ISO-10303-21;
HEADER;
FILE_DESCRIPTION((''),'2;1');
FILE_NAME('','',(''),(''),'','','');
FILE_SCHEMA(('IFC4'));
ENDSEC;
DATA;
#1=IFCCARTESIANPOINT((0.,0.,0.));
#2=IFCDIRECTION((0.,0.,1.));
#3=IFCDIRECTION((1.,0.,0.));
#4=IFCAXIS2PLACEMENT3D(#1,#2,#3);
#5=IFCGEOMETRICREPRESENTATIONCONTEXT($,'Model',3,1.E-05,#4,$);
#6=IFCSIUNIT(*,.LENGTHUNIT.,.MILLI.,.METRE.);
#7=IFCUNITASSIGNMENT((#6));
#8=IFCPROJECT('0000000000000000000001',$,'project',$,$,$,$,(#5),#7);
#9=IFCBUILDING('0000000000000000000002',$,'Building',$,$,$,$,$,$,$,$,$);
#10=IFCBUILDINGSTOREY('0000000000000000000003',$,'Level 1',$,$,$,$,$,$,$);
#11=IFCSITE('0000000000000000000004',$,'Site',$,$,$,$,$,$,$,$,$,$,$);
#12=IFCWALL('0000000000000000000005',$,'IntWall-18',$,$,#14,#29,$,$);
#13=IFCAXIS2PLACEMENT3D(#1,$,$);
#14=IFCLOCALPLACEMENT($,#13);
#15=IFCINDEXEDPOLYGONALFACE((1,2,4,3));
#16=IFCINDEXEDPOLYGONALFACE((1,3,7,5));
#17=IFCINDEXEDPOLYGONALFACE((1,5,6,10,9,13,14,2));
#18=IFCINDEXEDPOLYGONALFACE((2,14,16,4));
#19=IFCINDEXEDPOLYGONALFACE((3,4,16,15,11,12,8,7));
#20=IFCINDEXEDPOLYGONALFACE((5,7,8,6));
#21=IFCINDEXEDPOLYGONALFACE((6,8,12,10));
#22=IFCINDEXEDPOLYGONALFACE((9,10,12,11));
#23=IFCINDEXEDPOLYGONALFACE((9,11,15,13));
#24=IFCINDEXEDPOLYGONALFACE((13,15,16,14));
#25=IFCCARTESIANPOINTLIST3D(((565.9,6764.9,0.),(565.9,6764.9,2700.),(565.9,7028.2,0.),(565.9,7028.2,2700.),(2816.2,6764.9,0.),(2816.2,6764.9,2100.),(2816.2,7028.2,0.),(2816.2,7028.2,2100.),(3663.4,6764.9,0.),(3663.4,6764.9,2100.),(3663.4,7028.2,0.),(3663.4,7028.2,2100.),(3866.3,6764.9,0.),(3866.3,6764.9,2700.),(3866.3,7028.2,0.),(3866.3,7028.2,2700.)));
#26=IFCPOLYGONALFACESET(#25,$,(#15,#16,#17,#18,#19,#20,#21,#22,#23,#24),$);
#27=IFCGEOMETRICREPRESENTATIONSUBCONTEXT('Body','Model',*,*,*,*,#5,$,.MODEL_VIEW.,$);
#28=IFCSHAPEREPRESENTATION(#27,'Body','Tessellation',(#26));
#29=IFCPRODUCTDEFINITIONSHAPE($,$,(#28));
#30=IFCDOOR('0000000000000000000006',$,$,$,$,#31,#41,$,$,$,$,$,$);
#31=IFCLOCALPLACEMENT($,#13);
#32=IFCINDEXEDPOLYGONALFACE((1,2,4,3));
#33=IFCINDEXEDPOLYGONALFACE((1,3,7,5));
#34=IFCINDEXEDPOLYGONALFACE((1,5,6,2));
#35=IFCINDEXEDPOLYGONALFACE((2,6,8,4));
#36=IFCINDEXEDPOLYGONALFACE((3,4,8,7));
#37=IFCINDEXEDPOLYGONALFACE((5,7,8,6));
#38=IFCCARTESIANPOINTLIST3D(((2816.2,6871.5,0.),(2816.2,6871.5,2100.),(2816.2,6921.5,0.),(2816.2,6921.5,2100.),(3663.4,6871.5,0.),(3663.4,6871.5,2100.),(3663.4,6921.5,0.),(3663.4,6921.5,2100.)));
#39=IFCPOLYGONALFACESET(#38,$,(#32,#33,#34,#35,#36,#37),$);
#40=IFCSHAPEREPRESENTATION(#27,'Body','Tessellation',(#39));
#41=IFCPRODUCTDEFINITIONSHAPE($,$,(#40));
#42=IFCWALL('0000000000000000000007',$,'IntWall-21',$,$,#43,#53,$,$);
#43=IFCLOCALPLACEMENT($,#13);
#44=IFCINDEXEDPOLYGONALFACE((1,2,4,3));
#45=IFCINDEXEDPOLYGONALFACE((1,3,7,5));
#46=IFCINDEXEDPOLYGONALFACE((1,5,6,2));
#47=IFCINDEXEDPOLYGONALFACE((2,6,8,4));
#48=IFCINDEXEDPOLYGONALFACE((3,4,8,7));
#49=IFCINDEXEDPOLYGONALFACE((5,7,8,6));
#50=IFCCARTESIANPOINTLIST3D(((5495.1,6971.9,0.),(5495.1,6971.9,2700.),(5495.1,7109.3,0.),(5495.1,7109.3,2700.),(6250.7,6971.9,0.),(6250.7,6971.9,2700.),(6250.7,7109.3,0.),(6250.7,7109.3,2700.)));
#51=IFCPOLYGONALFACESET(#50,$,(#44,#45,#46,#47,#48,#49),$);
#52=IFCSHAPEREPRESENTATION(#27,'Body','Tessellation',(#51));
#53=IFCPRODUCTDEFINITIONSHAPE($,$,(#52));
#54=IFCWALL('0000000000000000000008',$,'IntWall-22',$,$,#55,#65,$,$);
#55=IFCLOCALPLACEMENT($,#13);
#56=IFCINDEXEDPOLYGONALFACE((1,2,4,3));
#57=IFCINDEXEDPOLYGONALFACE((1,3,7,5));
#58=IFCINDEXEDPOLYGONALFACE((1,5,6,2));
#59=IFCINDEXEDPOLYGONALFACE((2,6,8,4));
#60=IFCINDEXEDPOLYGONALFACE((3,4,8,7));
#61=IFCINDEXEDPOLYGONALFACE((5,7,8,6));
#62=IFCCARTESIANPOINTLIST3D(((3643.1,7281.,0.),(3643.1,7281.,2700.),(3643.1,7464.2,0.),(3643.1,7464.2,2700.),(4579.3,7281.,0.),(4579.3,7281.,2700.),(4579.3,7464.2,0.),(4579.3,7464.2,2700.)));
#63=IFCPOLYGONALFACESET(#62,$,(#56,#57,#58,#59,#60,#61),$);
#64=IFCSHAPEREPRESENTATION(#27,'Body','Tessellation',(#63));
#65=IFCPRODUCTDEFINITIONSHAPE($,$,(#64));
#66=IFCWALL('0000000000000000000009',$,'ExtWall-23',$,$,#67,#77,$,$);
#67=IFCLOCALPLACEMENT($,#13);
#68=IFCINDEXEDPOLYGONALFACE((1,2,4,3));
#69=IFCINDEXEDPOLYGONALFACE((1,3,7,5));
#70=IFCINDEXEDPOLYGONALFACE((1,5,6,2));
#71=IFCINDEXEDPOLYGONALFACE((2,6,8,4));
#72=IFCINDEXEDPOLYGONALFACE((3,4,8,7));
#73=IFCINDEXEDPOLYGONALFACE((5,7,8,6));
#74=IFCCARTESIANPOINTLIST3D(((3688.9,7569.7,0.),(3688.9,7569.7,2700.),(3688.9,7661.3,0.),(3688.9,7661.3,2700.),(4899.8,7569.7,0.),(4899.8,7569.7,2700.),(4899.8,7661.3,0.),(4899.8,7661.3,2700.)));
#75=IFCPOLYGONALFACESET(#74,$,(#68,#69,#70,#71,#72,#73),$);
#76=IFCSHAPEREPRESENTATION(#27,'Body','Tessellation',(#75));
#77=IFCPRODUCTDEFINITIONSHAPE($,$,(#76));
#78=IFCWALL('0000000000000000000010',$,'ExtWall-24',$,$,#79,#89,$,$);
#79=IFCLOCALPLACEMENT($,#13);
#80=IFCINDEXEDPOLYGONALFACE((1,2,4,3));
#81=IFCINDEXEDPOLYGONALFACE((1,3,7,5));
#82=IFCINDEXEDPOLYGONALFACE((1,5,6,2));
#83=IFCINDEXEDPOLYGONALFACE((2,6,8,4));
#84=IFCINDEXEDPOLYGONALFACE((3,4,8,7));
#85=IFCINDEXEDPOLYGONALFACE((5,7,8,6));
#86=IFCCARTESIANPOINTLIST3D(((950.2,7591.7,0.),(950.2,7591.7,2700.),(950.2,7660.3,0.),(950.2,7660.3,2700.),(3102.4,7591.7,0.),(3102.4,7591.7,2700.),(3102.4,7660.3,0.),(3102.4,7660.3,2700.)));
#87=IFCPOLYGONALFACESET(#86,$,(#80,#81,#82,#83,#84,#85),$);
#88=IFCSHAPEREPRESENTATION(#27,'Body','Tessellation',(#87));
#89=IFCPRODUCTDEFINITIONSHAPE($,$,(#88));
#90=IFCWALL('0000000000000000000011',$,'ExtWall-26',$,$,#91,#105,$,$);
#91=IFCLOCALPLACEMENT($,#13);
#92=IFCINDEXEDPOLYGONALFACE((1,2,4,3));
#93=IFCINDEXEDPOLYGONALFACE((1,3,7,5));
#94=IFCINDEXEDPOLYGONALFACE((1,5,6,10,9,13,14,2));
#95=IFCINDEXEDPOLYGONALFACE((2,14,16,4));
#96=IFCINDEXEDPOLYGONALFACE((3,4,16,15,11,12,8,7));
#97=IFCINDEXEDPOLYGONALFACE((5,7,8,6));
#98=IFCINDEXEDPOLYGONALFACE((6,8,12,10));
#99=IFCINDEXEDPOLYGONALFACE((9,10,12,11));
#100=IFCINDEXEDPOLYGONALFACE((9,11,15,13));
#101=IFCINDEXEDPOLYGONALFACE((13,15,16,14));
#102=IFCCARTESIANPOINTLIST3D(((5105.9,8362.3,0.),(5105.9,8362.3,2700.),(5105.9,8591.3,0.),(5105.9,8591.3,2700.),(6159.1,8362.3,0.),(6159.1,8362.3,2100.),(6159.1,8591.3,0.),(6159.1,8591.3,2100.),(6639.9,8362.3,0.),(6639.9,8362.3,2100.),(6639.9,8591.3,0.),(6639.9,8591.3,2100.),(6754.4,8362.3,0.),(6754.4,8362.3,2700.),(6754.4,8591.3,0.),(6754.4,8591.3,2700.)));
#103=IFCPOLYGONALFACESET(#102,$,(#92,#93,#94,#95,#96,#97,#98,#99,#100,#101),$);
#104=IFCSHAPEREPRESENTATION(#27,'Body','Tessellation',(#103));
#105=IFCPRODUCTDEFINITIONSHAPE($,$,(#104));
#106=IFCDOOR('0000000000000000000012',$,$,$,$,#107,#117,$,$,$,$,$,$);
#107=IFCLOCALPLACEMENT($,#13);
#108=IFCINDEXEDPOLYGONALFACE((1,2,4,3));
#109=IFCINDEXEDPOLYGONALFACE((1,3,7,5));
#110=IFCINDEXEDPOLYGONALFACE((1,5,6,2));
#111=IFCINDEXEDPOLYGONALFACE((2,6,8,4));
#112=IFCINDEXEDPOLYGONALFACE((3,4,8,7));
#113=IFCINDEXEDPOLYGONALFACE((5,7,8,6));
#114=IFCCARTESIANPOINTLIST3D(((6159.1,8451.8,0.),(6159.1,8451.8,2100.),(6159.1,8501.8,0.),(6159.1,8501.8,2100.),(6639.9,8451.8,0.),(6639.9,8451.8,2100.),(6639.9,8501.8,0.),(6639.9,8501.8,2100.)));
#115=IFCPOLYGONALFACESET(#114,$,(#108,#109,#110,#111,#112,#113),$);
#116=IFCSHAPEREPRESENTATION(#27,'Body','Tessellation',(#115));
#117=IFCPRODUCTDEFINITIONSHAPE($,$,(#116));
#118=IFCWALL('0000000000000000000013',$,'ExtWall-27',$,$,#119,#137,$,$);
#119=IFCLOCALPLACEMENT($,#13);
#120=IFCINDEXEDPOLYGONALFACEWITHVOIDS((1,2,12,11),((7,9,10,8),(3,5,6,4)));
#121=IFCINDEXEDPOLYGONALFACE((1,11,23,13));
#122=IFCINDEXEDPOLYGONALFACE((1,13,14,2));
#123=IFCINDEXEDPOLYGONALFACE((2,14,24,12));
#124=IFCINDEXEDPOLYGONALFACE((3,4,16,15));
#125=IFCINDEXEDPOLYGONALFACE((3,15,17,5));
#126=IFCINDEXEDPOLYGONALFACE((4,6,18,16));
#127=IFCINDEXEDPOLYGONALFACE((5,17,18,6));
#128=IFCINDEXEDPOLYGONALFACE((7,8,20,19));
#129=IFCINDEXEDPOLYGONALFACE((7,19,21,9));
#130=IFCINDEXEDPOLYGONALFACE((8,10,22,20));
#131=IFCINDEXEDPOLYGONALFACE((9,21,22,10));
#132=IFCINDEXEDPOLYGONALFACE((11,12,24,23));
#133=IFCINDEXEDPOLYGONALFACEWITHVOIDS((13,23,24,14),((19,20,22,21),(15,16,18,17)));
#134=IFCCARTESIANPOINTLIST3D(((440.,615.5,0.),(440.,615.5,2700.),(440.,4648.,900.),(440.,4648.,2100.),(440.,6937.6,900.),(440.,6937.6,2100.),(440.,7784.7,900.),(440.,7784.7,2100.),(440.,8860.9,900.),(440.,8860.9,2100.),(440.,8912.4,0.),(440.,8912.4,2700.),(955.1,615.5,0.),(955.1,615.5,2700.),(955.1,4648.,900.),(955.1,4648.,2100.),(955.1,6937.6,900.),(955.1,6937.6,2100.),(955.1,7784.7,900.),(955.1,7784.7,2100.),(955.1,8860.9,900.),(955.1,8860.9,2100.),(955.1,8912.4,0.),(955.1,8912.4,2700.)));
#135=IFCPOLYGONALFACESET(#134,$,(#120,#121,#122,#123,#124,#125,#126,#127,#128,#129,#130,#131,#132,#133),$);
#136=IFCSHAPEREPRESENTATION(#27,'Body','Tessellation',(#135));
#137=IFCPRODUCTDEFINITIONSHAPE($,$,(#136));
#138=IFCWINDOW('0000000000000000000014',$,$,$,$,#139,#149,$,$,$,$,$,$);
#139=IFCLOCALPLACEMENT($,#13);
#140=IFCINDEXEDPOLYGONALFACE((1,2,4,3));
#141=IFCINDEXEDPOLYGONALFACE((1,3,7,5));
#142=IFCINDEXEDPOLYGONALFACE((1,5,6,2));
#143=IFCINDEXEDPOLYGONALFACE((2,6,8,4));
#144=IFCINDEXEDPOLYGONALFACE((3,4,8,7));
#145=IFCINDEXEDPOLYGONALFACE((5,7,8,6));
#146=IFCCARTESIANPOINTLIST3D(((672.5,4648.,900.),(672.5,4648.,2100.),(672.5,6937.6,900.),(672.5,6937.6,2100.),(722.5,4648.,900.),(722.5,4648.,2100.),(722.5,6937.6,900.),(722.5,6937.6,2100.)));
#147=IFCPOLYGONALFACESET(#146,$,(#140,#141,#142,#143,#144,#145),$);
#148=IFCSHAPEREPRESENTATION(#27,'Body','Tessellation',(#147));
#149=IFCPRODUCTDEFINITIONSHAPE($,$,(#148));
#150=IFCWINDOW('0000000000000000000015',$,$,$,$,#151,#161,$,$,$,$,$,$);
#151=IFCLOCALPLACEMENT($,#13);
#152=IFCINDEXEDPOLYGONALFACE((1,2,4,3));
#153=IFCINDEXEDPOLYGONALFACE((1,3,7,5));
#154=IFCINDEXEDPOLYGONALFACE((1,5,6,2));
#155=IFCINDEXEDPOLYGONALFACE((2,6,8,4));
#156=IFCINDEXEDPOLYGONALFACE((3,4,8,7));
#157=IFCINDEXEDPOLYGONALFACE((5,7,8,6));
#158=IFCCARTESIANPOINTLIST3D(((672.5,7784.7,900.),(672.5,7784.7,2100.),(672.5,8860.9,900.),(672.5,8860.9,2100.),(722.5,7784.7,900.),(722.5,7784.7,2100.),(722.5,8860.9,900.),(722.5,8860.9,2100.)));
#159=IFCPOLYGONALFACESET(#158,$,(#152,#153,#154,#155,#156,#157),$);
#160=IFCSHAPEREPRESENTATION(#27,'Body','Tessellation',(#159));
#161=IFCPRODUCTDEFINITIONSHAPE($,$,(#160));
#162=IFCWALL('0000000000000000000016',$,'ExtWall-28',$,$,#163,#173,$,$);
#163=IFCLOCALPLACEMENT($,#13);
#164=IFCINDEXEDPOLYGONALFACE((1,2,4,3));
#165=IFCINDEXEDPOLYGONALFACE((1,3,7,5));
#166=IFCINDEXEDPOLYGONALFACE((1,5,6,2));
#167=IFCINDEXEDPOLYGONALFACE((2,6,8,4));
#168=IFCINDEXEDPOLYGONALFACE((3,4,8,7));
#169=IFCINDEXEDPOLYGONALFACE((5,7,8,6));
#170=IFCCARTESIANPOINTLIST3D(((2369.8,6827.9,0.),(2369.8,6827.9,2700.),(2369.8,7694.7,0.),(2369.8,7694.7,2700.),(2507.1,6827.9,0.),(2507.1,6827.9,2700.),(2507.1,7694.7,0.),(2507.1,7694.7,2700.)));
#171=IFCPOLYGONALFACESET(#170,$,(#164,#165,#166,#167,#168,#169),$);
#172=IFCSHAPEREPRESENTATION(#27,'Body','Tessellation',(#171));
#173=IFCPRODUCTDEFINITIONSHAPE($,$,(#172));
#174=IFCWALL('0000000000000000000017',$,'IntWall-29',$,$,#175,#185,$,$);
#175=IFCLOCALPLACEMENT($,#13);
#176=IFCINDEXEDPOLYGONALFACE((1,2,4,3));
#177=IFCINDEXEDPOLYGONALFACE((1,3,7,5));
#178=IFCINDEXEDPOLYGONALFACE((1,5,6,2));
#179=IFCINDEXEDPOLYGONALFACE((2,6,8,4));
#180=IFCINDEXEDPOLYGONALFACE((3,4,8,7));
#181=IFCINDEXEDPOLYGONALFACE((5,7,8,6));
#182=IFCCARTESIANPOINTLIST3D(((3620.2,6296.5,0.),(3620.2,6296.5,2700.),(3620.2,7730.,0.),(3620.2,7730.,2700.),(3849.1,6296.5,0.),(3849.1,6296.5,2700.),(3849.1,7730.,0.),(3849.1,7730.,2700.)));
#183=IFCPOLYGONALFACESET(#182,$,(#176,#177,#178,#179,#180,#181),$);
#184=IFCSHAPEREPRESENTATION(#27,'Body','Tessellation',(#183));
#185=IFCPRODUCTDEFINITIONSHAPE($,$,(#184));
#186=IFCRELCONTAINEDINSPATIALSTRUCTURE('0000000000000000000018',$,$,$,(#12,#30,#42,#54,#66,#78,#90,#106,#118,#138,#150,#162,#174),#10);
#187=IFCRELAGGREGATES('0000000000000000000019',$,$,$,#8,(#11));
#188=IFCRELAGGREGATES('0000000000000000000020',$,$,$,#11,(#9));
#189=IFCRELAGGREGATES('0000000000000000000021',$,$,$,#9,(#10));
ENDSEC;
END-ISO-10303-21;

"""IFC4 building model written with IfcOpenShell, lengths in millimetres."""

from ifc_helpers import new_model, si_unit, frame, origin_with_axes, place, context, subcontext, project, spatial, indexed_curve, outline, extrude, element, fill, save


model = new_model("IFC4")

# Units and contexts
model_context = context("Model", 3, precision=1e-05, world=origin_with_axes())
body_context = subcontext(model_context, "Body", "Model", "MODEL_VIEW")
ifc_project = project(units=[si_unit("LENGTHUNIT", "METRE", prefix="MILLI")], contexts=[model_context])

# Site, building, storey
site = spatial("IfcSite", under=ifc_project, Name="Site")
building = spatial("IfcBuilding", under=site, Name="Building")
storey = spatial("IfcBuildingStorey", under=building, Name="Level 1")

# Wall, opening, door
wall_1_placement = place(None, frame((565.9, 6896.5, 0.0), z_axis=(0.0, 0.0, 1.0), x_axis=(1.0, 0.0, 0.0)))
wall_1 = element("IfcWall", 1, at=wall_1_placement, inside=storey, Name="IntWall-18", context=body_context, shape_type="SweptSolid", body=[
    extrude(outline(indexed_curve([(0.0, 0.0), (0.0, 263.3), (3300.4, 263.3), (3300.4, 0.0), (0.0, 0.0)], self_intersect=False)), frame((0.0, -131.7, 0.0), z_axis=(0.0, 0.0, 1.0), x_axis=(1.0, 0.0, 0.0)), (0.0, 0.0, 1.0), 2700.0),
])
opening_1_placement = place(wall_1_placement, frame((2250.4, 0.0, 0.0), z_axis=(0.0, 0.0, 1.0), x_axis=(1.0, 0.0, 0.0)))
opening_1 = element("IfcOpeningElement", 2, at=opening_1_placement, cuts=wall_1, context=body_context, shape_type="SweptSolid", body=[
    extrude(outline(indexed_curve([(0.0, 0.0), (0.0, 363.3), (847.2, 363.3), (847.2, 0.0), (0.0, 0.0)], self_intersect=False)), frame((0.0, -181.7, 0.0), z_axis=(0.0, 0.0, 1.0), x_axis=(1.0, 0.0, 0.0)), (0.0, 0.0, 1.0), 2100.0),
])
door_1_placement = place(opening_1_placement, origin_with_axes())
door_1 = element("IfcDoor", 3, at=door_1_placement, inside=storey, context=body_context, shape_type="SweptSolid", body=[
    extrude(outline(indexed_curve([(0.0, 0.0), (0.0, 50.0), (847.2, 50.0), (847.2, 0.0), (0.0, 0.0)], self_intersect=False)), frame((0.0, -25.0, 0.0), z_axis=(0.0, 0.0, 1.0), x_axis=(1.0, 0.0, 0.0)), (0.0, 0.0, 1.0), 2100.0),
])
fill(opening_1, door_1)

# Walls
wall_2_placement = place(None, frame((5495.1, 7040.6, 0.0), z_axis=(0.0, 0.0, 1.0), x_axis=(1.0, 0.0, 0.0)))
element("IfcWall", 4, at=wall_2_placement, inside=storey, Name="IntWall-21", context=body_context, shape_type="SweptSolid", body=[
    extrude(outline(indexed_curve([(0.0, 0.0), (0.0, 137.4), (755.6, 137.4), (755.6, 0.0), (0.0, 0.0)], self_intersect=False)), frame((0.0, -68.7, 0.0), z_axis=(0.0, 0.0, 1.0), x_axis=(1.0, 0.0, 0.0)), (0.0, 0.0, 1.0), 2700.0),
])
wall_3_placement = place(None, frame((3643.1, 7372.6, 0.0), z_axis=(0.0, 0.0, 1.0), x_axis=(1.0, 0.0, 0.0)))
element("IfcWall", 5, at=wall_3_placement, inside=storey, Name="IntWall-22", context=body_context, shape_type="SweptSolid", body=[
    extrude(outline(indexed_curve([(0.0, 0.0), (0.0, 183.2), (936.2, 183.2), (936.2, 0.0), (0.0, 0.0)], self_intersect=False)), frame((0.0, -91.6, 0.0), z_axis=(0.0, 0.0, 1.0), x_axis=(1.0, 0.0, 0.0)), (0.0, 0.0, 1.0), 2700.0),
])
wall_4_placement = place(None, frame((3688.9, 7615.5, 0.0), z_axis=(0.0, 0.0, 1.0), x_axis=(1.0, 0.0, 0.0)))
element("IfcWall", 6, at=wall_4_placement, inside=storey, Name="ExtWall-23", context=body_context, shape_type="SweptSolid", body=[
    extrude(outline(indexed_curve([(0.0, 0.0), (0.0, 91.6), (1210.9, 91.6), (1210.9, 0.0), (0.0, 0.0)], self_intersect=False)), frame((0.0, -45.8, 0.0), z_axis=(0.0, 0.0, 1.0), x_axis=(1.0, 0.0, 0.0)), (0.0, 0.0, 1.0), 2700.0),
])
wall_5_placement = place(None, frame((950.2, 7626.0, 0.0), z_axis=(0.0, 0.0, 1.0), x_axis=(1.0, 0.0, 0.0)))
element("IfcWall", 7, at=wall_5_placement, inside=storey, Name="ExtWall-24", context=body_context, shape_type="SweptSolid", body=[
    extrude(outline(indexed_curve([(0.0, 0.0), (0.0, 68.7), (2152.3, 68.7), (2152.3, 0.0), (0.0, 0.0)], self_intersect=False)), frame((0.0, -34.3, 0.0), z_axis=(0.0, 0.0, 1.0), x_axis=(1.0, 0.0, 0.0)), (0.0, 0.0, 1.0), 2700.0),
])

# Wall, opening, door
wall_6_placement = place(None, frame((5105.9, 8476.8, 0.0), z_axis=(0.0, 0.0, 1.0), x_axis=(1.0, 0.0, 0.0)))
wall_6 = element("IfcWall", 8, at=wall_6_placement, inside=storey, Name="ExtWall-26", context=body_context, shape_type="SweptSolid", body=[
    extrude(outline(indexed_curve([(0.0, 0.0), (0.0, 229.0), (1648.5, 229.0), (1648.5, 0.0), (0.0, 0.0)], self_intersect=False)), frame((0.0, -114.5, 0.0), z_axis=(0.0, 0.0, 1.0), x_axis=(1.0, 0.0, 0.0)), (0.0, 0.0, 1.0), 2700.0),
])
opening_2_placement = place(wall_6_placement, frame((1053.2, 0.0, 0.0), z_axis=(0.0, 0.0, 1.0), x_axis=(1.0, 0.0, 0.0)))
opening_2 = element("IfcOpeningElement", 9, at=opening_2_placement, cuts=wall_6, context=body_context, shape_type="SweptSolid", body=[
    extrude(outline(indexed_curve([(0.0, 0.0), (0.0, 329.0), (480.8, 329.0), (480.8, 0.0), (0.0, 0.0)], self_intersect=False)), frame((0.0, -164.5, 0.0), z_axis=(0.0, 0.0, 1.0), x_axis=(1.0, 0.0, 0.0)), (0.0, 0.0, 1.0), 2100.0),
])
door_2_placement = place(opening_2_placement, frame((0.0, 0.0, 0.0), z_axis=(0.0, 0.0, 1.0), x_axis=(1.0, 0.0, 0.0)))
door_2 = element("IfcDoor", 10, at=door_2_placement, inside=storey, context=body_context, shape_type="SweptSolid", body=[
    extrude(outline(indexed_curve([(0.0, 0.0), (0.0, 50.0), (480.8, 50.0), (480.8, 0.0), (0.0, 0.0)], self_intersect=False)), frame((0.0, -25.0, 0.0), z_axis=(0.0, 0.0, 1.0), x_axis=(1.0, 0.0, 0.0)), (0.0, 0.0, 1.0), 2100.0),
])
fill(opening_2, door_2)

# Wall, openings, windows
wall_7_placement = place(None, frame((697.5, 615.5, 0.0), z_axis=(0.0, 0.0, 1.0), x_axis=(0.0, 1.0, 0.0)))
wall_7 = element("IfcWall", 11, at=wall_7_placement, inside=storey, Name="ExtWall-27", context=body_context, shape_type="SweptSolid", body=[
    extrude(outline(indexed_curve([(0.0, 0.0), (0.0, 515.2), (8296.9, 515.2), (8296.9, 0.0), (0.0, 0.0)], self_intersect=False)), frame((0.0, -257.6, 0.0), z_axis=(0.0, 0.0, 1.0), x_axis=(1.0, 0.0, 0.0)), (0.0, 0.0, 1.0), 2700.0),
])
opening_3_placement = place(wall_7_placement, frame((4032.4, 0.0, 900.0), z_axis=(0.0, 0.0, 1.0), x_axis=(1.0, 0.0, 0.0)))
opening_3 = element("IfcOpeningElement", 12, at=opening_3_placement, cuts=wall_7, context=body_context, shape_type="SweptSolid", body=[
    extrude(outline(indexed_curve([(0.0, 0.0), (0.0, 615.2), (2289.6, 615.2), (2289.6, 0.0), (0.0, 0.0)], self_intersect=False)), frame((0.0, -307.6, 0.0), z_axis=(0.0, 0.0, 1.0), x_axis=(1.0, 0.0, 0.0)), (0.0, 0.0, 1.0), 1200.0),
])
opening_4_placement = place(wall_7_placement, frame((7169.2, 0.0, 900.0), z_axis=(0.0, 0.0, 1.0), x_axis=(1.0, 0.0, 0.0)))
opening_4 = element("IfcOpeningElement", 13, at=opening_4_placement, cuts=wall_7, context=body_context, shape_type="SweptSolid", body=[
    extrude(outline(indexed_curve([(0.0, 0.0), (0.0, 615.2), (1076.1, 615.2), (1076.1, 0.0), (0.0, 0.0)], self_intersect=False)), frame((0.0, -307.6, 0.0), z_axis=(0.0, 0.0, 1.0), x_axis=(1.0, 0.0, 0.0)), (0.0, 0.0, 1.0), 1200.0),
])
window_1_placement = place(opening_3_placement, origin_with_axes())
window_1 = element("IfcWindow", 14, at=window_1_placement, inside=storey, context=body_context, shape_type="SweptSolid", body=[
    extrude(outline(indexed_curve([(0.0, 0.0), (0.0, 50.0), (2289.6, 50.0), (2289.6, 0.0), (0.0, 0.0)], self_intersect=False)), frame((0.0, -25.0, 0.0), z_axis=(0.0, 0.0, 1.0), x_axis=(1.0, 0.0, 0.0)), (0.0, 0.0, 1.0), 1200.0),
])
fill(opening_3, window_1)
window_2_placement = place(opening_4_placement, origin_with_axes())
window_2 = element("IfcWindow", 15, at=window_2_placement, inside=storey, context=body_context, shape_type="SweptSolid", body=[
    extrude(outline(indexed_curve([(0.0, 0.0), (0.0, 50.0), (1076.1, 50.0), (1076.1, 0.0), (0.0, 0.0)], self_intersect=False)), frame((0.0, -25.0, 0.0), z_axis=(0.0, 0.0, 1.0), x_axis=(1.0, 0.0, 0.0)), (0.0, 0.0, 1.0), 1200.0),
])
fill(opening_4, window_2)

# Walls
wall_8_placement = place(None, frame((2438.5, 6827.9, 0.0), z_axis=(0.0, 0.0, 1.0), x_axis=(0.0, 1.0, 0.0)))
element("IfcWall", 16, at=wall_8_placement, inside=storey, Name="ExtWall-28", context=body_context, shape_type="SweptSolid", body=[
    extrude(outline(indexed_curve([(0.0, 0.0), (0.0, 137.4), (866.8, 137.4), (866.8, 0.0), (0.0, 0.0)], self_intersect=False)), frame((0.0, -68.7, 0.0), z_axis=(0.0, 0.0, 1.0), x_axis=(1.0, 0.0, 0.0)), (0.0, 0.0, 1.0), 2700.0),
])
wall_9_placement = place(None, frame((3734.7, 6296.5, 0.0), z_axis=(0.0, 0.0, 1.0), x_axis=(0.0, 1.0, 0.0)))
element("IfcWall", 17, at=wall_9_placement, inside=storey, Name="IntWall-29", context=body_context, shape_type="SweptSolid", body=[
    extrude(outline(indexed_curve([(0.0, 0.0), (0.0, 229.0), (1433.5, 229.0), (1433.5, 0.0), (0.0, 0.0)], self_intersect=False)), frame((0.0, -114.5, 0.0), z_axis=(0.0, 0.0, 1.0), x_axis=(1.0, 0.0, 0.0)), (0.0, 0.0, 1.0), 2700.0),
])

save(model, "model.ifc")
